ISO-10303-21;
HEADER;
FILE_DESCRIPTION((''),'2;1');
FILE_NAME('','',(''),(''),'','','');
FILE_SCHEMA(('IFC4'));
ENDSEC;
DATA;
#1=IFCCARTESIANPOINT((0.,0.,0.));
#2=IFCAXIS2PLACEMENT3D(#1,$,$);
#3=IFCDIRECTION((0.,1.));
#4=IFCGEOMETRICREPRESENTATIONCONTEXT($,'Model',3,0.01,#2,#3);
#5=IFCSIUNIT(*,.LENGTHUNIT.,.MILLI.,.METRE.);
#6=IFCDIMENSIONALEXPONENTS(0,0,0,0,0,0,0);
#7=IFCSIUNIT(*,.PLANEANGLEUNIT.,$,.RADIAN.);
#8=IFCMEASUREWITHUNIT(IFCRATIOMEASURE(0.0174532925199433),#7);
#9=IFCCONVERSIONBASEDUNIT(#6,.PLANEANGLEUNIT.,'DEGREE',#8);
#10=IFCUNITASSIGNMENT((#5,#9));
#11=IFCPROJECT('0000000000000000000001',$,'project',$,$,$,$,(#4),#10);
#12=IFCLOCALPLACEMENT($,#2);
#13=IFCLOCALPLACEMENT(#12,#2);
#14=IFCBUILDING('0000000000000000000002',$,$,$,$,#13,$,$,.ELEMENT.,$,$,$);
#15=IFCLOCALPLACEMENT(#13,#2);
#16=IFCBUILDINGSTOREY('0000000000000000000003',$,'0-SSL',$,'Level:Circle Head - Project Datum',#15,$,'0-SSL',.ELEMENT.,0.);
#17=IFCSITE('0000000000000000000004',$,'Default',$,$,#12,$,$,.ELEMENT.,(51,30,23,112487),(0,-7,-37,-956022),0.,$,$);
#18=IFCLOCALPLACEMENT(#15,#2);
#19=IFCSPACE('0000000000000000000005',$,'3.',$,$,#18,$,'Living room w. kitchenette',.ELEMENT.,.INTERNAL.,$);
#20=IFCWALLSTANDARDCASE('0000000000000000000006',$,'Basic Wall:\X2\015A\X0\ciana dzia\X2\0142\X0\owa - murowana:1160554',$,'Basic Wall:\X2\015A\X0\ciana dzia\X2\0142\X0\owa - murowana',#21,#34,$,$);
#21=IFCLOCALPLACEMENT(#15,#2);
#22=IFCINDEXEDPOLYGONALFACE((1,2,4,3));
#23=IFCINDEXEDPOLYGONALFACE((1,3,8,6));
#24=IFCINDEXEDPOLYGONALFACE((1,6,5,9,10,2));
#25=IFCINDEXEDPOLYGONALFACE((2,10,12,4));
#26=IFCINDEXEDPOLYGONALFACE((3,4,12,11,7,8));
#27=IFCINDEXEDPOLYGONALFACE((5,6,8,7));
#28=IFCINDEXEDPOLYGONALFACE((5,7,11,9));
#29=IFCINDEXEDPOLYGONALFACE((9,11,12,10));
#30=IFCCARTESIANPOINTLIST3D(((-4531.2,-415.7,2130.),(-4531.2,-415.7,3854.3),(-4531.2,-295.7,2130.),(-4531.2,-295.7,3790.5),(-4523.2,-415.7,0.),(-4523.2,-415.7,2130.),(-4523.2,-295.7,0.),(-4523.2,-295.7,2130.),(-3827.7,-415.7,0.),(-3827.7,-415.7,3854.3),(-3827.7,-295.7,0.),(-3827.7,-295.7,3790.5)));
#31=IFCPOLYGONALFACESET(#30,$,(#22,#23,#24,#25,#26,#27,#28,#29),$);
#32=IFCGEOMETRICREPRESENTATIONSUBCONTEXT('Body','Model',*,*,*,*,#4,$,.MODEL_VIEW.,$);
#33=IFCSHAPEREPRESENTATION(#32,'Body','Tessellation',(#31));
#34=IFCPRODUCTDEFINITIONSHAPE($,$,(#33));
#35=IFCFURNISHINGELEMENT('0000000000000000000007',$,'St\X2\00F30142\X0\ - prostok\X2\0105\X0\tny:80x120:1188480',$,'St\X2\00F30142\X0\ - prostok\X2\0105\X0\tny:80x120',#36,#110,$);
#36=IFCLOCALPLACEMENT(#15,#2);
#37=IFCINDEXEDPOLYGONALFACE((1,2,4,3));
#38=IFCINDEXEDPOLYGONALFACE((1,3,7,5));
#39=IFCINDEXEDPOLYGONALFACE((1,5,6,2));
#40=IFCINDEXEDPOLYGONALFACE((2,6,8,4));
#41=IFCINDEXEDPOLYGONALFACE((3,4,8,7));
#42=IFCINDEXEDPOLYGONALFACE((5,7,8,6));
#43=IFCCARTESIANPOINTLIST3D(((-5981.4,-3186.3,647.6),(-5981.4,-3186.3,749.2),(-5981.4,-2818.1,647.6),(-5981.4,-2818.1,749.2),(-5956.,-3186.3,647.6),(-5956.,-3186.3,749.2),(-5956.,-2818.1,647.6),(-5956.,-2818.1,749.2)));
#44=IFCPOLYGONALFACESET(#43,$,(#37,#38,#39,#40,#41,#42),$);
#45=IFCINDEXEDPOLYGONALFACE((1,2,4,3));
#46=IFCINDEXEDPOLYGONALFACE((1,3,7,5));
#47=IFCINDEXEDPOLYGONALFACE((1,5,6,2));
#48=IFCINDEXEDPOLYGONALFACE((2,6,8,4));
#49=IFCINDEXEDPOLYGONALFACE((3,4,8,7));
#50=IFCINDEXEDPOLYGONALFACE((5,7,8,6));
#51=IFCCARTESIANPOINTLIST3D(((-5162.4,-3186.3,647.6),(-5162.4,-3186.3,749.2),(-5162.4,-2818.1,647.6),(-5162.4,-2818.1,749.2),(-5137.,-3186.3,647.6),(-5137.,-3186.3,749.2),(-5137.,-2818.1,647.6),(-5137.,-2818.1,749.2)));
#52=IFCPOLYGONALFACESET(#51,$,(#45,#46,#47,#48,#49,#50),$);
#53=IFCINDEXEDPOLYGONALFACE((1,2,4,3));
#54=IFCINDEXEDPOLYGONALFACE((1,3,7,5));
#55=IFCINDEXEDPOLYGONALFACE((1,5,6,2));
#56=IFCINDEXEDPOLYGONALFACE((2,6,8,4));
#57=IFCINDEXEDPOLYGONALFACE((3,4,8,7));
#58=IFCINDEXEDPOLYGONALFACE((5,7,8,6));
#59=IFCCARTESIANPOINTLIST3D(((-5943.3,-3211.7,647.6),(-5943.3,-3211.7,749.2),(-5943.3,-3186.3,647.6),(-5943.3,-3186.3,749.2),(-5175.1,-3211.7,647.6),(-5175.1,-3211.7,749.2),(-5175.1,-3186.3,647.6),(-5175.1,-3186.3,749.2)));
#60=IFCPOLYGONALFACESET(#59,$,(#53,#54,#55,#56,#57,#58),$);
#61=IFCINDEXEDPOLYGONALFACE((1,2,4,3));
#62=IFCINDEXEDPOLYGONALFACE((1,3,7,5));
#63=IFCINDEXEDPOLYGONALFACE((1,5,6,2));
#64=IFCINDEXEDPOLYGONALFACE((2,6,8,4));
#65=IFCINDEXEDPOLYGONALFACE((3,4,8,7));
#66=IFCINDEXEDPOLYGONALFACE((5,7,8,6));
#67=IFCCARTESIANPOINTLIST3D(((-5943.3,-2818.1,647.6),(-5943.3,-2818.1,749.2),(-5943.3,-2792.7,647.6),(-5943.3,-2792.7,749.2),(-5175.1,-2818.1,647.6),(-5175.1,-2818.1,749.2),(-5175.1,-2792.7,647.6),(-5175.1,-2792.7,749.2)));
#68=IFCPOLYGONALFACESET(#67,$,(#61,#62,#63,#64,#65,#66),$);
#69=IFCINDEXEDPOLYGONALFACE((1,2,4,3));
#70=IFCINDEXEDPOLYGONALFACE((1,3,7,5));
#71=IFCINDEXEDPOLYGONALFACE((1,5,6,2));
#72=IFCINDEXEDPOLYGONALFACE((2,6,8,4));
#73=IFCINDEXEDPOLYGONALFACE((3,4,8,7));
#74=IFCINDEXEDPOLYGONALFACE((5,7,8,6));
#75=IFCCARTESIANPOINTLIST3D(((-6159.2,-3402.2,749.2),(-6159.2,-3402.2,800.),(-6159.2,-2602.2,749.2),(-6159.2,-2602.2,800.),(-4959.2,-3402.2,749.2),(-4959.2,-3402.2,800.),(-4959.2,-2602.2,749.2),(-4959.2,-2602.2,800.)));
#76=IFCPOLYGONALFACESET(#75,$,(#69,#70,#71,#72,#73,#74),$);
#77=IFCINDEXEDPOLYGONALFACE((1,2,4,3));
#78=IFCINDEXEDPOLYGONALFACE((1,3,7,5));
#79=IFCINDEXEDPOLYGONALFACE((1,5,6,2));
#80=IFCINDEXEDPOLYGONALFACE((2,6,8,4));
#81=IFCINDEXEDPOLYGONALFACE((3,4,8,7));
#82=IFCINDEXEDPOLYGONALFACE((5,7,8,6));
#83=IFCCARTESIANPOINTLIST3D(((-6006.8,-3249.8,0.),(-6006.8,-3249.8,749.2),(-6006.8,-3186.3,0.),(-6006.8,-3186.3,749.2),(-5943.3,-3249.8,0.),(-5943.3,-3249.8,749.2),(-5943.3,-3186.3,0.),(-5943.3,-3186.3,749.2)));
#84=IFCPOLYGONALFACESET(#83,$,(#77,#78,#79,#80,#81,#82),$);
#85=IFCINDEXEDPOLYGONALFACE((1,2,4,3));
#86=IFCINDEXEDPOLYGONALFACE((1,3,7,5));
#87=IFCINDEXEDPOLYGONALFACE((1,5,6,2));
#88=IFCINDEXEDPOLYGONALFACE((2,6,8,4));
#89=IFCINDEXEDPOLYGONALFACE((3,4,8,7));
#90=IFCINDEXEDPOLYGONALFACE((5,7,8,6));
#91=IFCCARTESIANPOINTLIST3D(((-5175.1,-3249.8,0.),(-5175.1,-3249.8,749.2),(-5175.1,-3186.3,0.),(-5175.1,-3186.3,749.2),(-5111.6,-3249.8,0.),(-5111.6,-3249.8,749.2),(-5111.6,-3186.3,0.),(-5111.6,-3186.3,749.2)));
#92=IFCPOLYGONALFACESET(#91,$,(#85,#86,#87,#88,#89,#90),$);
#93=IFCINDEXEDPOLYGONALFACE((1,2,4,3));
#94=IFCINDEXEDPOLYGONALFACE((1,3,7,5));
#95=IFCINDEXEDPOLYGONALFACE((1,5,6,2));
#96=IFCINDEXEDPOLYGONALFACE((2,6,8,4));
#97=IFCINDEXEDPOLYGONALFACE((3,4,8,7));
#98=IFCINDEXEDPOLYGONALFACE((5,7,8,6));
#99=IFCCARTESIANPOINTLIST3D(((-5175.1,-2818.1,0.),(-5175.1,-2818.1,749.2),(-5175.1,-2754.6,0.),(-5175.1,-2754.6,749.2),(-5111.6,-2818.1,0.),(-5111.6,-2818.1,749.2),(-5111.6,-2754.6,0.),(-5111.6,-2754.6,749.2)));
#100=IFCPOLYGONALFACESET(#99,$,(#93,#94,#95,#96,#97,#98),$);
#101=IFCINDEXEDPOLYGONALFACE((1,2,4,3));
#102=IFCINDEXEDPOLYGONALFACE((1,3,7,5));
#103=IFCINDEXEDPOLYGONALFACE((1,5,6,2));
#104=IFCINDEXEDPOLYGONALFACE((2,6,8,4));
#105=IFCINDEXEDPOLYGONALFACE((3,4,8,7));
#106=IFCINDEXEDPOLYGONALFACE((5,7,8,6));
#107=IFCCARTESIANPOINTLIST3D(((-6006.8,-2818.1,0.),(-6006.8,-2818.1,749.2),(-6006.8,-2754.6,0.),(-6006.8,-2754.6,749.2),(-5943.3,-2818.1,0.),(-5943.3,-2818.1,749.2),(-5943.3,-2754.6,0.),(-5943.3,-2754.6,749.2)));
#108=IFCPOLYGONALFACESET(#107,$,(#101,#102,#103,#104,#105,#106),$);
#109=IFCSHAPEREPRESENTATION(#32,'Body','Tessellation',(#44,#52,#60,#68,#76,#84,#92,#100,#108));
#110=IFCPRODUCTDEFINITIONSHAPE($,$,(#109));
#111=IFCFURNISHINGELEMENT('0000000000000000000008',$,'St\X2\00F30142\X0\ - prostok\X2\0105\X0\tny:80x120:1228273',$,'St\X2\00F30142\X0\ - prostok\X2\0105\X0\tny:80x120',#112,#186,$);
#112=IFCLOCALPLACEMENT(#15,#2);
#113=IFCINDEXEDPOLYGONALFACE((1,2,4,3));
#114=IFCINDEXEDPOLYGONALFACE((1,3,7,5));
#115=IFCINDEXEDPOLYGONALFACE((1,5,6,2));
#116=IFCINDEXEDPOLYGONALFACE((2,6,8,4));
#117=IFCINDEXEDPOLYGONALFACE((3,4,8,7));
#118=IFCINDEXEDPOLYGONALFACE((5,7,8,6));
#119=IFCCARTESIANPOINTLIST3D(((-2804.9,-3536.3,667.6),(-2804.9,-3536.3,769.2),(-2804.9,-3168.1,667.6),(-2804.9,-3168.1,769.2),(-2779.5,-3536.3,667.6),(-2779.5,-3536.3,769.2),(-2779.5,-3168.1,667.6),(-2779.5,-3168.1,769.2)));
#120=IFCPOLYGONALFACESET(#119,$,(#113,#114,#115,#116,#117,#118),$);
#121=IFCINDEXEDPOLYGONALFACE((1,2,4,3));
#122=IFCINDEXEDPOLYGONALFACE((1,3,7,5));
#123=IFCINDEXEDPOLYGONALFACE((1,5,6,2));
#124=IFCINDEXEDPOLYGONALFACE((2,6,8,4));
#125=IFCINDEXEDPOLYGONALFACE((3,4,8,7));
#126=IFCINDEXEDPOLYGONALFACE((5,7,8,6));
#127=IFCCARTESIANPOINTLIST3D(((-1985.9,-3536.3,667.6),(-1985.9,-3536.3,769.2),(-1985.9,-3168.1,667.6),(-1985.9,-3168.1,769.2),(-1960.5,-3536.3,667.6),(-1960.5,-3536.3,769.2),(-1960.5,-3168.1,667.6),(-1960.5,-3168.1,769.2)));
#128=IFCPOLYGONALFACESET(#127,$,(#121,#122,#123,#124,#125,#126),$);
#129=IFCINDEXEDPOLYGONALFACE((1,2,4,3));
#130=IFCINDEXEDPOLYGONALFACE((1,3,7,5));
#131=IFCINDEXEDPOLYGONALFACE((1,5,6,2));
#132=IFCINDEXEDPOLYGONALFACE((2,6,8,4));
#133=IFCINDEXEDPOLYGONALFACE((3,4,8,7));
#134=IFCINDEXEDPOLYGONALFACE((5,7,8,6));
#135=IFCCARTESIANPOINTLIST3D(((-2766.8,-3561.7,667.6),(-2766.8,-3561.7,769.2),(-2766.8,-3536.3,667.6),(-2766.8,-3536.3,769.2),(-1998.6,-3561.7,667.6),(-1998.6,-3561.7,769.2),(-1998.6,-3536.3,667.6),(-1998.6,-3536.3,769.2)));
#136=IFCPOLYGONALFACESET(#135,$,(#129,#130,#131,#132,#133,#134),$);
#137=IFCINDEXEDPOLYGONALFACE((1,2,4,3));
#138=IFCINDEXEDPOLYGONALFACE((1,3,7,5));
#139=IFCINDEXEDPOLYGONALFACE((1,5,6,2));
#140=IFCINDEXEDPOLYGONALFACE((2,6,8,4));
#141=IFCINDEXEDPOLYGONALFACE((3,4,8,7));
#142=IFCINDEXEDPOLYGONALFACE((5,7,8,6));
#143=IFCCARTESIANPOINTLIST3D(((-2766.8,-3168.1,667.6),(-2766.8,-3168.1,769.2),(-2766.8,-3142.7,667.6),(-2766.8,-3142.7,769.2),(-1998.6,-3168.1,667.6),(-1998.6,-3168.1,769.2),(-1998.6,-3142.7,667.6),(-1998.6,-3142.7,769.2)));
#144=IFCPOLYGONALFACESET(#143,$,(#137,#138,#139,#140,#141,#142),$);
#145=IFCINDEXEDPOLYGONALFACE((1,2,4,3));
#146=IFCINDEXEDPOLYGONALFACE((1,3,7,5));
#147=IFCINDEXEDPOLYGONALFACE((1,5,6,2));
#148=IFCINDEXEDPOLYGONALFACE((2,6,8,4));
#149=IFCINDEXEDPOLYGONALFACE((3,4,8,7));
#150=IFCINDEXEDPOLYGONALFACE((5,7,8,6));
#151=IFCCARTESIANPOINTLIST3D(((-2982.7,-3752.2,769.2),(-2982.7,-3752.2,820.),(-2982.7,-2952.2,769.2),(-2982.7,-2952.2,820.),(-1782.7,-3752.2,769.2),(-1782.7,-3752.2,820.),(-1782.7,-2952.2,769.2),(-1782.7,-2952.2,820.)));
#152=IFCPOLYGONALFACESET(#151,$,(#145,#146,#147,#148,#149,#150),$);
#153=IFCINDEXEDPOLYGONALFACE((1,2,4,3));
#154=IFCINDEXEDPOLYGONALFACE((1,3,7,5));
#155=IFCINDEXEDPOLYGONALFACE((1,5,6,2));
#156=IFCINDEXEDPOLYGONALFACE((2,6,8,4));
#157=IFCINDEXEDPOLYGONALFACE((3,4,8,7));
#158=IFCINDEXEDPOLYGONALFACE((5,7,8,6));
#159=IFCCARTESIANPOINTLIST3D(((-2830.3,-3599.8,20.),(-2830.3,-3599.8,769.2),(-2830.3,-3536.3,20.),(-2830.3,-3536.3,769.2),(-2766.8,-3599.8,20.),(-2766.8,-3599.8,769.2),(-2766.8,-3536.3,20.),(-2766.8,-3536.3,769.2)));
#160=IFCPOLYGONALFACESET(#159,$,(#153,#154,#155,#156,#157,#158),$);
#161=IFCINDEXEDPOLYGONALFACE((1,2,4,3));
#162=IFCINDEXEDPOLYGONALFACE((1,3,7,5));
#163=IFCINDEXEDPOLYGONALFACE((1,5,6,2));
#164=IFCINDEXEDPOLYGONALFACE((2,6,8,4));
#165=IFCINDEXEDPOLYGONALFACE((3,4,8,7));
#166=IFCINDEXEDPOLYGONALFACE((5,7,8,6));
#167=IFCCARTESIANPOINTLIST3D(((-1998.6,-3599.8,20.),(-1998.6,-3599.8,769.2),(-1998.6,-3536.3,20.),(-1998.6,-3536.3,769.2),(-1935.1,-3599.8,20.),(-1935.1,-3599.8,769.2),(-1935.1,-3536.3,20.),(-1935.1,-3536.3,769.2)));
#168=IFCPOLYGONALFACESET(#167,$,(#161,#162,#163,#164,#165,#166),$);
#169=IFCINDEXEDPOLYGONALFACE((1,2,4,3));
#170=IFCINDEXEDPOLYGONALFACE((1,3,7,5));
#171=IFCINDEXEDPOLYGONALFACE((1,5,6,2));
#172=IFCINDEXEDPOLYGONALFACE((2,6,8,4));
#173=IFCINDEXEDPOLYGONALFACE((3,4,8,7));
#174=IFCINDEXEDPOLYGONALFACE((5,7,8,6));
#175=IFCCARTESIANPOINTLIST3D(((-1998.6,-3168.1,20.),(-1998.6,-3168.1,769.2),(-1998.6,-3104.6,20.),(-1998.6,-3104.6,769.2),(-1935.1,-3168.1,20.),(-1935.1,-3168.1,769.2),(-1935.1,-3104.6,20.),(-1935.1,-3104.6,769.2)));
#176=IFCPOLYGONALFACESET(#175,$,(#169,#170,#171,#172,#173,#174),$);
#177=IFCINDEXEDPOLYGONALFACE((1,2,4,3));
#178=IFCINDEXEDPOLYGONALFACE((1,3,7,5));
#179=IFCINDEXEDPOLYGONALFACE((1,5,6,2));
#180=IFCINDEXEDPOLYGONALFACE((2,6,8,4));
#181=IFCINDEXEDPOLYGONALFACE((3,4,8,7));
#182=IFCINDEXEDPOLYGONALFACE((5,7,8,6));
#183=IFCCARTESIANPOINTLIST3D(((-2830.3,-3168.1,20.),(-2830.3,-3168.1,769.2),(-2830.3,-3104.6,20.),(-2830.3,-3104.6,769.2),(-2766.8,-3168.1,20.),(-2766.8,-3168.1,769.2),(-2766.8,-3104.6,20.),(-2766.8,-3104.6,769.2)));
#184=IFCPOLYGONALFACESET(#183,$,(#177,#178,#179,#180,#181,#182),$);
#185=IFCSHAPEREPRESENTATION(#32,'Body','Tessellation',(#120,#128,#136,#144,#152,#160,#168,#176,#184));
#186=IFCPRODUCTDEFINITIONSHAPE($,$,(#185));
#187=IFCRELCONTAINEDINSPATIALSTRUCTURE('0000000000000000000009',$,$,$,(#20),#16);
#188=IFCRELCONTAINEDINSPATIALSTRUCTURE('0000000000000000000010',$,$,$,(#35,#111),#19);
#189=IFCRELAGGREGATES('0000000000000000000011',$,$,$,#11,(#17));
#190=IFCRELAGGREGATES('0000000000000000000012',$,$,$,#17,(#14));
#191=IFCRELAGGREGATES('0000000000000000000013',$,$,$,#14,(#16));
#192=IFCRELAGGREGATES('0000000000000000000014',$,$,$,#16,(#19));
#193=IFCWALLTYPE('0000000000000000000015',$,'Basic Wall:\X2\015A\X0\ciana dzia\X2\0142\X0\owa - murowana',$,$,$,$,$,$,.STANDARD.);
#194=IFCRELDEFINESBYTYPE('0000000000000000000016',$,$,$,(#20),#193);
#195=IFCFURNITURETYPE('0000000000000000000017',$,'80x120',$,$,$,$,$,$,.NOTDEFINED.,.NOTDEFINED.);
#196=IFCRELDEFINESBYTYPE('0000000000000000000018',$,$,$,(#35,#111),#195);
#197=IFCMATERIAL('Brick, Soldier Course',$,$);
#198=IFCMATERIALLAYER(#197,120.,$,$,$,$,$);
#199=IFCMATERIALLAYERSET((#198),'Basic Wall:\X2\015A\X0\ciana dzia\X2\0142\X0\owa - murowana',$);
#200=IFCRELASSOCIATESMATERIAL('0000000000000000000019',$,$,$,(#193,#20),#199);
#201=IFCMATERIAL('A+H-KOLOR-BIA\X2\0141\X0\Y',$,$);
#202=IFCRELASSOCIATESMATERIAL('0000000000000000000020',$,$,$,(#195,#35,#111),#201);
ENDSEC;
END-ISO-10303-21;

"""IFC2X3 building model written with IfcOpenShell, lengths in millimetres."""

from ifc_helpers import new_model, entity, si_unit, converted_unit, direction, frame, frame_2d, origin, origin_2d_with_axis, place, context, subcontext, project, spatial, polyline, rectangle, extrude, clip, bounded_halfspace, source, transform, mapped, material, layer, layer_set, layer_usage, type_object, type_shapes, element, save


model = new_model("IFC2X3")

# Units and contexts
model_context = context("Model", 3, precision=0.01, world=origin(), true_north=direction((0.0, 1.0)))
body_context = subcontext(model_context, "Body", "Model", "MODEL_VIEW")
ifc_project = project(units=[si_unit("LENGTHUNIT", "METRE", prefix="MILLI"), converted_unit("PLANEANGLEUNIT", "DEGREE", entity("IfcRatioMeasure", 0.0174532925199433), si_unit("PLANEANGLEUNIT", "RADIAN"), dimensions=[0, 0, 0, 0, 0, 0, 0])], contexts=[model_context])

# Site, building, storey
site_placement = place(None, origin())
site = spatial("IfcSite", under=ifc_project, at=site_placement, Name="Default", CompositionType="ELEMENT", RefLatitude=(51, 30, 23, 112487), RefLongitude=(0, -7, -37, -956022), RefElevation=0.0)
building_placement = place(site_placement, origin())
building = spatial("IfcBuilding", under=site, at=building_placement, CompositionType="ELEMENT")
storey_placement = place(building_placement, origin())
storey = spatial("IfcBuildingStorey", under=building, at=storey_placement, Name="0-SSL", ObjectType="Level:Circle Head - Project Datum", LongName="0-SSL", CompositionType="ELEMENT", Elevation=0.0)

# Wall, opening
ifc_material_1 = material(Name="Brick, Soldier Course")
ifc_layer_1 = layer(ifc_material_1, 120.0)
ifc_layer_set_1 = layer_set([ifc_layer_1], Name="Basic Wall:Ściana działowa - murowana")
ifc_layer_usage_1 = layer_usage(ifc_layer_set_1, "AXIS2", "NEGATIVE", 60.0)
wall_type_1 = type_object("IfcWallType", Name="Basic Wall:Ściana działowa - murowana", PredefinedType="STANDARD", material=ifc_layer_set_1)
wall_1_placement = place(storey_placement, frame((-4531.2, -355.7, 0.0)))
wall_1 = element("IfcWallStandardCase", 1, at=wall_1_placement, inside=storey, type_object=wall_type_1, material=ifc_layer_usage_1, Name="Basic Wall:Ściana działowa - murowana:1160554", ObjectType="Basic Wall:Ściana działowa - murowana", context=body_context, shape_type="Clipping", body=[
    clip(extrude(rectangle(XDim=703.5, YDim=120.0, at=frame_2d((351.8, 0.0), x_axis=(-1.0, 0.0))), origin(), (0.0, 0.0, 1.0), 3854.3), bounded_halfspace(frame((0.0, -60.0, 3854.3), z_axis=(0.0, 0.469472, 0.882948), x_axis=(-1.0, 0.0, 0.0)), False, frame((0.0, -60.0, 3854.3)), polyline([(0.0, 0.0), (691.5, 0.0), (703.5, 0.0), (703.5, 120.0), (691.5, 120.0), (0.0, 120.0), (0.0, 0.0)]))),
])
opening_1_placement = place(wall_1_placement, origin())
element("IfcOpeningElement", 2, at=opening_1_placement, cuts=wall_1, ObjectType="Opening", context=body_context, shape_type="SweptSolid", body=[
    extrude(rectangle(XDim=2130.0, YDim=920.0, at=frame_2d((0.0, 0.0), x_axis=(1.0, 0.0))), frame((-452.0, -1585.0, 1065.0), z_axis=(0.0, 1.0, 0.0), x_axis=(0.0, 0.0, 1.0)), (0.0, 0.0, 1.0), 3048.0),
])

# Shared definitions
space_placement = place(storey_placement, origin())
space = spatial("IfcSpace", under=storey, at=space_placement, Name="3.", LongName="Living room w. kitchenette", CompositionType="ELEMENT", InteriorOrExteriorSpace="INTERNAL")

# Furnishing elements
ifc_material_2 = material(Name="A+H-KOLOR-BIAŁY")
furniture_type_1 = type_object("IfcFurnitureType", Name="80x120", material=ifc_material_2)
shared_shape_1 = source(origin(), body_context, "Body", "SweptSolid", [
    extrude(rectangle(XDim=25.4, YDim=368.2, at=origin_2d_with_axis()), frame((409.5, 0.0, 647.6)), (0.0, 0.0, 1.0), 101.6),
    extrude(rectangle(XDim=368.2, YDim=25.4, at=origin_2d_with_axis()), frame((-409.5, 0.0, 647.6), z_axis=(0.0, 0.0, 1.0), x_axis=(0.0, 1.0, 0.0)), (0.0, 0.0, 1.0), 101.6),
    extrude(rectangle(XDim=768.2, YDim=25.4, at=frame_2d((0.0, 0.0), x_axis=(1.0, 0.0))), frame((0.0, 196.8, 647.6), z_axis=(0.0, 0.0, 1.0), x_axis=(-1.0, 0.0, 0.0)), (0.0, 0.0, 1.0), 101.6),
    extrude(rectangle(XDim=25.4, YDim=768.2, at=origin_2d_with_axis()), frame((0.0, -196.8, 647.6), z_axis=(0.0, 0.0, 1.0), x_axis=(0.0, 1.0, 0.0)), (0.0, 0.0, 1.0), 101.6),
    extrude(rectangle(XDim=1200.0, YDim=800.0, at=origin_2d_with_axis()), frame((0.0, 0.0, 749.2), z_axis=(0.0, 0.0, 1.0), x_axis=(-1.0, 0.0, 0.0)), (0.0, 0.0, 1.0), 50.8),
    extrude(rectangle(XDim=63.5, YDim=63.5, at=origin_2d_with_axis()), frame((415.9, 215.9, 0.0), z_axis=(0.0, 0.0, 1.0), x_axis=(0.0, -1.0, 0.0)), (0.0, 0.0, 1.0), 749.2),
    extrude(rectangle(XDim=63.5, YDim=63.5, at=origin_2d_with_axis()), frame((-415.9, 215.9, 0.0), z_axis=(0.0, 0.0, 1.0), x_axis=(-1.0, 0.0, 0.0)), (0.0, 0.0, 1.0), 749.2),
    extrude(rectangle(XDim=63.5, YDim=63.5, at=origin_2d_with_axis()), frame((-415.9, -215.9, 0.0), z_axis=(0.0, 0.0, 1.0), x_axis=(0.0, 1.0, 0.0)), (0.0, 0.0, 1.0), 749.2),
    extrude(rectangle(XDim=63.5, YDim=63.5, at=frame_2d((0.0, 0.0), x_axis=(1.0, 0.0))), frame((415.9, -215.9, 0.0)), (0.0, 0.0, 1.0), 749.2),
])
type_shapes(furniture_type_1, [shared_shape_1])
for number, where, z_axis, x_axis, name in (
    (3, (-5559.2, -3002.2, 0.0), (0.0, 0.0, 1.0), (-1.0, 0.0, 0.0), "Stół - prostokątny:80x120:1188480"),
    (4, (-2382.7, -3352.2, 20.0), (0.0, 0.0, 1.0), (-1.0, 0.0, 0.0), "Stół - prostokątny:80x120:1228273"),
):
    element("IfcFurnishingElement", number, at=place(space_placement, frame(where, z_axis=z_axis, x_axis=x_axis)), inside=space, type_object=furniture_type_1, material=ifc_material_2, Name=name, ObjectType="Stół - prostokątny:80x120", context=body_context, shape_type="MappedRepresentation", body=[
        mapped(shared_shape_1, transform((0.0, 0.0, 0.0), scale=1.0)),
    ])

save(model, "model.ifc")
